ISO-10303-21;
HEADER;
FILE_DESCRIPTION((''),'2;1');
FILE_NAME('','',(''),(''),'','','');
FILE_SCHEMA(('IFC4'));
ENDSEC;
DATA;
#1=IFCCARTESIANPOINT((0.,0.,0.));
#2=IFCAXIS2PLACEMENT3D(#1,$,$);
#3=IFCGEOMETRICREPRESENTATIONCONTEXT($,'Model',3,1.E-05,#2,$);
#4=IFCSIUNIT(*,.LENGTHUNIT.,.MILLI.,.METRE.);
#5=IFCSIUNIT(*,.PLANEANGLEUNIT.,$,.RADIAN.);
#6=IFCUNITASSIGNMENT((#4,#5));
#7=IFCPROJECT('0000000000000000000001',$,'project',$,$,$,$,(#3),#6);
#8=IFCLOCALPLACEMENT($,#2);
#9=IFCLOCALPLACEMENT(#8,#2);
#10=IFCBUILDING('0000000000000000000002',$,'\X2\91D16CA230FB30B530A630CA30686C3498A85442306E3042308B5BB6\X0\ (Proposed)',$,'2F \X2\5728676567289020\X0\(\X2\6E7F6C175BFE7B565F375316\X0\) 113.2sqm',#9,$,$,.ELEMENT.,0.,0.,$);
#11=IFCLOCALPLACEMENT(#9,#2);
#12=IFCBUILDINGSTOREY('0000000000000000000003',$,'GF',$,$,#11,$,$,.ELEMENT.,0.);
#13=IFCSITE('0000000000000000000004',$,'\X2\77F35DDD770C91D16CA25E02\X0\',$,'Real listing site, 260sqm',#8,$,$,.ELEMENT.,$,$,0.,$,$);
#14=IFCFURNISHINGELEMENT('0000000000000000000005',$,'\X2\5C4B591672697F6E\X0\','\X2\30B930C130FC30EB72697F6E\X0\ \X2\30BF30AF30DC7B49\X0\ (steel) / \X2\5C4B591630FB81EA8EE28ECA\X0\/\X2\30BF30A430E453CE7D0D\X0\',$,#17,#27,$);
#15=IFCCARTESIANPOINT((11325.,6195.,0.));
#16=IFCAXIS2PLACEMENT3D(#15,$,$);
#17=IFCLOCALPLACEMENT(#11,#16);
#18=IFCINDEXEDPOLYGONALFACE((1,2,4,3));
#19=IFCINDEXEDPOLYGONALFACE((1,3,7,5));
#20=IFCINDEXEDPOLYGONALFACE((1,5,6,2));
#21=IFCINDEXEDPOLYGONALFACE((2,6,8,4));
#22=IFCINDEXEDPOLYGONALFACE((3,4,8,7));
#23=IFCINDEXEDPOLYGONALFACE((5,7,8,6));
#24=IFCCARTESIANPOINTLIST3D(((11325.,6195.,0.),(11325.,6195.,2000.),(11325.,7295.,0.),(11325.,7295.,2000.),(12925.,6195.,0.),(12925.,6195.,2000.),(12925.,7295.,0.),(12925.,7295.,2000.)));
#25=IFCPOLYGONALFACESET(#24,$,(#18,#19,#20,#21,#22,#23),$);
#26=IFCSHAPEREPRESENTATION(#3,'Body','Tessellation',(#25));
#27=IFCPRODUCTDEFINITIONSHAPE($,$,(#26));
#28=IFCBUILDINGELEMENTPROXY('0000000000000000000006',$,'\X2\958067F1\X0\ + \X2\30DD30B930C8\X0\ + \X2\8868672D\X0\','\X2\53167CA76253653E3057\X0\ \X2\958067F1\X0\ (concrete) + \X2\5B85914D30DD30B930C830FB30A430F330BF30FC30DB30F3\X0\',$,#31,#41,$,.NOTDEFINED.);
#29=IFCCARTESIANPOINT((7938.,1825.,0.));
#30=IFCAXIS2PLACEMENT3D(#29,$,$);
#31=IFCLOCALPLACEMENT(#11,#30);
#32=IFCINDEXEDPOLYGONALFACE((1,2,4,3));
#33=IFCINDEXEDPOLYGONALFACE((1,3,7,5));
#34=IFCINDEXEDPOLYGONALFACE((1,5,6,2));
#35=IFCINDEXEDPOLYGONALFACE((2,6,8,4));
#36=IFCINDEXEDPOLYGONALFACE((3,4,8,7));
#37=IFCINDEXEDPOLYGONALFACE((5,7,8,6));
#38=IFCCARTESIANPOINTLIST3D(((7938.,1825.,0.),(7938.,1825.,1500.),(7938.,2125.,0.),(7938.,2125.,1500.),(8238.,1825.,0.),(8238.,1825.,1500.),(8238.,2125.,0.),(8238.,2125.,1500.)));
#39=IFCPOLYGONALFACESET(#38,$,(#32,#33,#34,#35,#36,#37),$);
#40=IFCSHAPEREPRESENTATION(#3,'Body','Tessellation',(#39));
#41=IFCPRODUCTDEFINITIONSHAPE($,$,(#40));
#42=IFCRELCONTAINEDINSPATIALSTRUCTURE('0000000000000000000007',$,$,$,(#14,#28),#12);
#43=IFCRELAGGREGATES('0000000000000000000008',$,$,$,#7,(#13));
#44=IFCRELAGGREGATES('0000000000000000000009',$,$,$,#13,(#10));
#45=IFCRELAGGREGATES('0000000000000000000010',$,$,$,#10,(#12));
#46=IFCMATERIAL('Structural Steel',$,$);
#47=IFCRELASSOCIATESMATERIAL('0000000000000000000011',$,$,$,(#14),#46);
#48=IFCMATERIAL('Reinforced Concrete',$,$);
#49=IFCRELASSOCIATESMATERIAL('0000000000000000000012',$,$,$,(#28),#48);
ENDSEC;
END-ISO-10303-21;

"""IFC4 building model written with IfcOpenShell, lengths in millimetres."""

from ifc_helpers import new_model, si_unit, frame, frame_2d, origin, place, context, project, spatial, rectangle, extrude, material, element, save


model = new_model("IFC4")

# Units and contexts
model_context = context("Model", 3, precision=1e-05, world=origin())
ifc_project = project(units=[si_unit("LENGTHUNIT", "METRE", prefix="MILLI"), si_unit("PLANEANGLEUNIT", "RADIAN")], contexts=[model_context])

# Site, building, storey
site_placement = place(None, origin())
site = spatial("IfcSite", under=ifc_project, at=site_placement, Name="石川県金沢市", ObjectType="Real listing site, 260sqm", CompositionType="ELEMENT", RefElevation=0.0)
building_placement = place(site_placement, origin())
building = spatial("IfcBuilding", under=site, at=building_placement, Name="金沢・サウナと水風呂のある家 (Proposed)", ObjectType="2F 在来木造(湿気対策強化) 113.2sqm", CompositionType="ELEMENT", ElevationOfRefHeight=0.0, ElevationOfTerrain=0.0)
storey_placement = place(building_placement, origin())
storey = spatial("IfcBuildingStorey", under=building, at=storey_placement, Name="GF", CompositionType="ELEMENT", Elevation=0.0)

# Shared definitions
ifc_material_1 = material(Name="Reinforced Concrete")

# Shared definitions
ifc_material_2 = material(Name="Structural Steel")

# Furnishing element
furnishing_1_placement = place(storey_placement, frame((11325.0, 6195.0, 0.0)))
element("IfcFurnishingElement", 1, at=furnishing_1_placement, inside=storey, material=ifc_material_2, Name="屋外物置", Description="スチール物置 タクボ等 (steel) / 屋外・自転車/タイヤ収納", context=model_context, shape_type="SweptSolid", body=[
    extrude(rectangle(XDim=1600.0, YDim=1100.0, at=frame_2d((800.0, 550.0))), frame((11325.0, 6195.0, 0.0)), (0.0, 0.0, 1.0), 2000.0),
])

# Building element proxy
proxy_placement = place(storey_placement, frame((7938.0, 1825.0, 0.0)))
element("IfcBuildingElementProxy", 2, at=proxy_placement, inside=storey, material=ifc_material_1, Name="門柱 + ポスト + 表札", Description="化粧打放し 門柱 (concrete) + 宅配ポスト・インターホン", PredefinedType="NOTDEFINED", context=model_context, shape_type="SweptSolid", body=[
    extrude(rectangle(XDim=300.0, YDim=300.0, at=frame_2d((150.0, 150.0))), frame((7938.0, 1825.0, 0.0)), (0.0, 0.0, 1.0), 1500.0),
])

save(model, "model.ifc")
